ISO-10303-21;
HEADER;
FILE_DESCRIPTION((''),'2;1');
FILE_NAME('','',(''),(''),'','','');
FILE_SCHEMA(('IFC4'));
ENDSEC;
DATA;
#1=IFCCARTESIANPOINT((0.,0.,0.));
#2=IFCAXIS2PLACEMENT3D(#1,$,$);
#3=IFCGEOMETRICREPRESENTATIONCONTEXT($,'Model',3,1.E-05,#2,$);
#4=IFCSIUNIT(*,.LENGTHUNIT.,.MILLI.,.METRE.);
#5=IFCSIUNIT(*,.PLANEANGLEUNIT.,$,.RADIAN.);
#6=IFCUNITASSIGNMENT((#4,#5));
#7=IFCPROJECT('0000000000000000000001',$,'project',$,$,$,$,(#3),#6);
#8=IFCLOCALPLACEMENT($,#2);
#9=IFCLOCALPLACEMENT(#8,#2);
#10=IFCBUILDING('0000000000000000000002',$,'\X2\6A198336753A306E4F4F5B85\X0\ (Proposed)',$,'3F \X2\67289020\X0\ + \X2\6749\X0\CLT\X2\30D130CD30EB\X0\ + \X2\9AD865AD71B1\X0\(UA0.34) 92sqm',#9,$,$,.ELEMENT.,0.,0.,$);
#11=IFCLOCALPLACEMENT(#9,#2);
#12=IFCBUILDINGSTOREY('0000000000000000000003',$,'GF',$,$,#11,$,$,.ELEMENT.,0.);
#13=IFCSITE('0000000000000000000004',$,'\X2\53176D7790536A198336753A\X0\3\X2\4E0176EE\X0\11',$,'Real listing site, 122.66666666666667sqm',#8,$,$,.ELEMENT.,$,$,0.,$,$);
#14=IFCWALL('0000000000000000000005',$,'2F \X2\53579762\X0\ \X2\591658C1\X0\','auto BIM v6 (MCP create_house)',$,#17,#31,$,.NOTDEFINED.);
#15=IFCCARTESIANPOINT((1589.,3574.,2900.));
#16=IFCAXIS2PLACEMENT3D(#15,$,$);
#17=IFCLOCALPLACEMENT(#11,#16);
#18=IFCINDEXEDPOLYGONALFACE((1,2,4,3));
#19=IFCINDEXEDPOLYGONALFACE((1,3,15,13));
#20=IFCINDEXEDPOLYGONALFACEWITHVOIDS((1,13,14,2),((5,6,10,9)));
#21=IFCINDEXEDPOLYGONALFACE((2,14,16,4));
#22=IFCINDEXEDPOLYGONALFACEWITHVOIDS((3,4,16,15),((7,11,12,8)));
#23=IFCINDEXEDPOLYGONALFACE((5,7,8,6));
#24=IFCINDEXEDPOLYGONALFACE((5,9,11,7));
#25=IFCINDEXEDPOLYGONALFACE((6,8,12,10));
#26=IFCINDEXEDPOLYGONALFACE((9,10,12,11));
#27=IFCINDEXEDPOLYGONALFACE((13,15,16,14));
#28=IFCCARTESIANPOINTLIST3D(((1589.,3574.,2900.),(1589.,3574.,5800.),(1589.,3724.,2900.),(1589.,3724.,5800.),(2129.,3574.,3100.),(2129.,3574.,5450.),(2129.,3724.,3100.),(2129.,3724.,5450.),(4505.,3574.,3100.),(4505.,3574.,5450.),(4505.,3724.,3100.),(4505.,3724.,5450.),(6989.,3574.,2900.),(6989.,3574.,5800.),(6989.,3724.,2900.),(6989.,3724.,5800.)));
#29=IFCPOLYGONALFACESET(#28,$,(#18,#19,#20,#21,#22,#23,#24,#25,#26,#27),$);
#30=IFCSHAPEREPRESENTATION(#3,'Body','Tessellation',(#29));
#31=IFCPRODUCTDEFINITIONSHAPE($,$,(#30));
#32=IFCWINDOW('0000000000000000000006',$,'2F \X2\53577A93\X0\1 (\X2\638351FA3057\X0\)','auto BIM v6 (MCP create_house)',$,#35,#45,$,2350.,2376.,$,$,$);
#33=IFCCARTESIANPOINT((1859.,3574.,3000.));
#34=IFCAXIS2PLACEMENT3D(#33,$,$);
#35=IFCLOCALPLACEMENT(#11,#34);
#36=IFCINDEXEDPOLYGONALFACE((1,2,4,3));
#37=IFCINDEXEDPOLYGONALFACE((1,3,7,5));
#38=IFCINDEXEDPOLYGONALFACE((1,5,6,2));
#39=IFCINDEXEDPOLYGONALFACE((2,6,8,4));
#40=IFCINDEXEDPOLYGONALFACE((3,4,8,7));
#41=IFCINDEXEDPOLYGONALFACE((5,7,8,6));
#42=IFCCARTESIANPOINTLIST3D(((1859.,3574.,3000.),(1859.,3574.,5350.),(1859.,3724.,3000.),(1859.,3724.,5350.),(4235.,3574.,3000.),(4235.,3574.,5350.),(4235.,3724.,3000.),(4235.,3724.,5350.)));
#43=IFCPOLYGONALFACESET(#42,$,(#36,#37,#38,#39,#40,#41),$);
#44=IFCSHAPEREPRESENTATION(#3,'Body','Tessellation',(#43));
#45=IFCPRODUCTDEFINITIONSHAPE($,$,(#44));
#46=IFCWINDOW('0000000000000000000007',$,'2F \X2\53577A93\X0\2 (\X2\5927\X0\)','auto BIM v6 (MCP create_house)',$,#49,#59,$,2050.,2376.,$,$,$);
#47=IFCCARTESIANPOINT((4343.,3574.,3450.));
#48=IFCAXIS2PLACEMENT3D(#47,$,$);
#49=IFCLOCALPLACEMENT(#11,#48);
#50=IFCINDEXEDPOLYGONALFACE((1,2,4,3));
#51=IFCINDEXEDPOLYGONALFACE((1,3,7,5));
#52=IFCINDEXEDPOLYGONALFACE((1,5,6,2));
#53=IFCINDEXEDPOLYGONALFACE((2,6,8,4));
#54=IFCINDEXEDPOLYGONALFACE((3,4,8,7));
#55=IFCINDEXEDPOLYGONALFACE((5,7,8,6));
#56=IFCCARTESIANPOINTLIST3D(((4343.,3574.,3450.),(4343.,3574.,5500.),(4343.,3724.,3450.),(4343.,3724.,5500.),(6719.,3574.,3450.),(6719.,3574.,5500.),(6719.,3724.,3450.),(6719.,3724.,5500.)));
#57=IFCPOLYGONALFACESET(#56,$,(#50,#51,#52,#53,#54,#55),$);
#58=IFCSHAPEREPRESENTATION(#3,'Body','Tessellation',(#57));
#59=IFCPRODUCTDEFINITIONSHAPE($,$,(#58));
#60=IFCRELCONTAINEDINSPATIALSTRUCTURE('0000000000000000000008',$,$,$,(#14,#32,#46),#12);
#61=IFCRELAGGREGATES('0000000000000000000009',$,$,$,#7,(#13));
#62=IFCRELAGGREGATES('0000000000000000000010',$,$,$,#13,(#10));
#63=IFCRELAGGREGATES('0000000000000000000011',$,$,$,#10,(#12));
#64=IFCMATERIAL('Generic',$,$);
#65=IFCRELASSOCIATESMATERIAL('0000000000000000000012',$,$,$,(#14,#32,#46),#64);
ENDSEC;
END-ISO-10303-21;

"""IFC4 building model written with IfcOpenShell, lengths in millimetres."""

from ifc_helpers import new_model, si_unit, frame, frame_2d, origin, place, context, project, spatial, rectangle, extrude, material, element, fill, save


model = new_model("IFC4")

# Units and contexts
model_context = context("Model", 3, precision=1e-05, world=origin())
ifc_project = project(units=[si_unit("LENGTHUNIT", "METRE", prefix="MILLI"), si_unit("PLANEANGLEUNIT", "RADIAN")], contexts=[model_context])

# Site, building, storey
site_placement = place(None, origin())
site = spatial("IfcSite", under=ifc_project, at=site_placement, Name="北海道標茶町3丁目11", ObjectType="Real listing site, 122.66666666666667sqm", CompositionType="ELEMENT", RefElevation=0.0)
building_placement = place(site_placement, origin())
building = spatial("IfcBuilding", under=site, at=building_placement, Name="標茶町の住宅 (Proposed)", ObjectType="3F 木造 + 杉CLTパネル + 高断熱(UA0.34) 92sqm", CompositionType="ELEMENT", ElevationOfRefHeight=0.0, ElevationOfTerrain=0.0)
storey_placement = place(building_placement, origin())
storey = spatial("IfcBuildingStorey", under=building, at=storey_placement, Name="GF", CompositionType="ELEMENT", Elevation=0.0)

# Shared definitions
ifc_material = material(Name="Generic")

# Wall, openings, windows
wall_1_placement = place(storey_placement, frame((1589.0, 3574.0, 2900.0)))
wall_1 = element("IfcWall", 1, at=wall_1_placement, inside=storey, material=ifc_material, Name="2F 南面 外壁", Description="auto BIM v6 (MCP create_house)", PredefinedType="NOTDEFINED", context=model_context, shape_type="SweptSolid", body=[
    extrude(rectangle(XDim=5400.0, YDim=150.0, at=frame_2d((2700.0, 75.0))), frame((1589.0, 3574.0, 2900.0)), (0.0, 0.0, 1.0), 2900.0),
])
opening_1_placement = place(storey_placement, frame((1859.0, 3574.0, 3000.0)))
opening_1 = element("IfcOpeningElement", 2, at=opening_1_placement, cuts=wall_1, PredefinedType="NOTDEFINED", context=model_context, shape_type="SweptSolid", body=[
    extrude(rectangle(XDim=2376.0, YDim=150.0, at=frame_2d((1188.0, 75.0))), frame((1859.0, 3574.0, 3000.0)), (0.0, 0.0, 1.0), 2350.0),
])
opening_2_placement = place(storey_placement, frame((4343.0, 3574.0, 3450.0)))
opening_2 = element("IfcOpeningElement", 3, at=opening_2_placement, cuts=wall_1, PredefinedType="NOTDEFINED", context=model_context, shape_type="SweptSolid", body=[
    extrude(rectangle(XDim=2376.0, YDim=150.0, at=frame_2d((1188.0, 75.0))), frame((4343.0, 3574.0, 3450.0)), (0.0, 0.0, 1.0), 2050.0),
])
window_1_placement = place(storey_placement, frame((1859.0, 3574.0, 3000.0)))
window_1 = element("IfcWindow", 4, at=window_1_placement, inside=storey, material=ifc_material, Name="2F 南窓1 (掃出し)", Description="auto BIM v6 (MCP create_house)", OverallHeight=2350.0, OverallWidth=2376.0, context=model_context, shape_type="SweptSolid", body=[
    extrude(rectangle(XDim=2376.0, YDim=150.0, at=frame_2d((1188.0, 75.0))), frame((1859.0, 3574.0, 3000.0)), (0.0, 0.0, 1.0), 2350.0),
])
fill(opening_1, window_1)
window_2_placement = place(storey_placement, frame((4343.0, 3574.0, 3450.0)))
window_2 = element("IfcWindow", 5, at=window_2_placement, inside=storey, material=ifc_material, Name="2F 南窓2 (大)", Description="auto BIM v6 (MCP create_house)", OverallHeight=2050.0, OverallWidth=2376.0, context=model_context, shape_type="SweptSolid", body=[
    extrude(rectangle(XDim=2376.0, YDim=150.0, at=frame_2d((1188.0, 75.0))), frame((4343.0, 3574.0, 3450.0)), (0.0, 0.0, 1.0), 2050.0),
])
fill(opening_2, window_2)

save(model, "model.ifc")
